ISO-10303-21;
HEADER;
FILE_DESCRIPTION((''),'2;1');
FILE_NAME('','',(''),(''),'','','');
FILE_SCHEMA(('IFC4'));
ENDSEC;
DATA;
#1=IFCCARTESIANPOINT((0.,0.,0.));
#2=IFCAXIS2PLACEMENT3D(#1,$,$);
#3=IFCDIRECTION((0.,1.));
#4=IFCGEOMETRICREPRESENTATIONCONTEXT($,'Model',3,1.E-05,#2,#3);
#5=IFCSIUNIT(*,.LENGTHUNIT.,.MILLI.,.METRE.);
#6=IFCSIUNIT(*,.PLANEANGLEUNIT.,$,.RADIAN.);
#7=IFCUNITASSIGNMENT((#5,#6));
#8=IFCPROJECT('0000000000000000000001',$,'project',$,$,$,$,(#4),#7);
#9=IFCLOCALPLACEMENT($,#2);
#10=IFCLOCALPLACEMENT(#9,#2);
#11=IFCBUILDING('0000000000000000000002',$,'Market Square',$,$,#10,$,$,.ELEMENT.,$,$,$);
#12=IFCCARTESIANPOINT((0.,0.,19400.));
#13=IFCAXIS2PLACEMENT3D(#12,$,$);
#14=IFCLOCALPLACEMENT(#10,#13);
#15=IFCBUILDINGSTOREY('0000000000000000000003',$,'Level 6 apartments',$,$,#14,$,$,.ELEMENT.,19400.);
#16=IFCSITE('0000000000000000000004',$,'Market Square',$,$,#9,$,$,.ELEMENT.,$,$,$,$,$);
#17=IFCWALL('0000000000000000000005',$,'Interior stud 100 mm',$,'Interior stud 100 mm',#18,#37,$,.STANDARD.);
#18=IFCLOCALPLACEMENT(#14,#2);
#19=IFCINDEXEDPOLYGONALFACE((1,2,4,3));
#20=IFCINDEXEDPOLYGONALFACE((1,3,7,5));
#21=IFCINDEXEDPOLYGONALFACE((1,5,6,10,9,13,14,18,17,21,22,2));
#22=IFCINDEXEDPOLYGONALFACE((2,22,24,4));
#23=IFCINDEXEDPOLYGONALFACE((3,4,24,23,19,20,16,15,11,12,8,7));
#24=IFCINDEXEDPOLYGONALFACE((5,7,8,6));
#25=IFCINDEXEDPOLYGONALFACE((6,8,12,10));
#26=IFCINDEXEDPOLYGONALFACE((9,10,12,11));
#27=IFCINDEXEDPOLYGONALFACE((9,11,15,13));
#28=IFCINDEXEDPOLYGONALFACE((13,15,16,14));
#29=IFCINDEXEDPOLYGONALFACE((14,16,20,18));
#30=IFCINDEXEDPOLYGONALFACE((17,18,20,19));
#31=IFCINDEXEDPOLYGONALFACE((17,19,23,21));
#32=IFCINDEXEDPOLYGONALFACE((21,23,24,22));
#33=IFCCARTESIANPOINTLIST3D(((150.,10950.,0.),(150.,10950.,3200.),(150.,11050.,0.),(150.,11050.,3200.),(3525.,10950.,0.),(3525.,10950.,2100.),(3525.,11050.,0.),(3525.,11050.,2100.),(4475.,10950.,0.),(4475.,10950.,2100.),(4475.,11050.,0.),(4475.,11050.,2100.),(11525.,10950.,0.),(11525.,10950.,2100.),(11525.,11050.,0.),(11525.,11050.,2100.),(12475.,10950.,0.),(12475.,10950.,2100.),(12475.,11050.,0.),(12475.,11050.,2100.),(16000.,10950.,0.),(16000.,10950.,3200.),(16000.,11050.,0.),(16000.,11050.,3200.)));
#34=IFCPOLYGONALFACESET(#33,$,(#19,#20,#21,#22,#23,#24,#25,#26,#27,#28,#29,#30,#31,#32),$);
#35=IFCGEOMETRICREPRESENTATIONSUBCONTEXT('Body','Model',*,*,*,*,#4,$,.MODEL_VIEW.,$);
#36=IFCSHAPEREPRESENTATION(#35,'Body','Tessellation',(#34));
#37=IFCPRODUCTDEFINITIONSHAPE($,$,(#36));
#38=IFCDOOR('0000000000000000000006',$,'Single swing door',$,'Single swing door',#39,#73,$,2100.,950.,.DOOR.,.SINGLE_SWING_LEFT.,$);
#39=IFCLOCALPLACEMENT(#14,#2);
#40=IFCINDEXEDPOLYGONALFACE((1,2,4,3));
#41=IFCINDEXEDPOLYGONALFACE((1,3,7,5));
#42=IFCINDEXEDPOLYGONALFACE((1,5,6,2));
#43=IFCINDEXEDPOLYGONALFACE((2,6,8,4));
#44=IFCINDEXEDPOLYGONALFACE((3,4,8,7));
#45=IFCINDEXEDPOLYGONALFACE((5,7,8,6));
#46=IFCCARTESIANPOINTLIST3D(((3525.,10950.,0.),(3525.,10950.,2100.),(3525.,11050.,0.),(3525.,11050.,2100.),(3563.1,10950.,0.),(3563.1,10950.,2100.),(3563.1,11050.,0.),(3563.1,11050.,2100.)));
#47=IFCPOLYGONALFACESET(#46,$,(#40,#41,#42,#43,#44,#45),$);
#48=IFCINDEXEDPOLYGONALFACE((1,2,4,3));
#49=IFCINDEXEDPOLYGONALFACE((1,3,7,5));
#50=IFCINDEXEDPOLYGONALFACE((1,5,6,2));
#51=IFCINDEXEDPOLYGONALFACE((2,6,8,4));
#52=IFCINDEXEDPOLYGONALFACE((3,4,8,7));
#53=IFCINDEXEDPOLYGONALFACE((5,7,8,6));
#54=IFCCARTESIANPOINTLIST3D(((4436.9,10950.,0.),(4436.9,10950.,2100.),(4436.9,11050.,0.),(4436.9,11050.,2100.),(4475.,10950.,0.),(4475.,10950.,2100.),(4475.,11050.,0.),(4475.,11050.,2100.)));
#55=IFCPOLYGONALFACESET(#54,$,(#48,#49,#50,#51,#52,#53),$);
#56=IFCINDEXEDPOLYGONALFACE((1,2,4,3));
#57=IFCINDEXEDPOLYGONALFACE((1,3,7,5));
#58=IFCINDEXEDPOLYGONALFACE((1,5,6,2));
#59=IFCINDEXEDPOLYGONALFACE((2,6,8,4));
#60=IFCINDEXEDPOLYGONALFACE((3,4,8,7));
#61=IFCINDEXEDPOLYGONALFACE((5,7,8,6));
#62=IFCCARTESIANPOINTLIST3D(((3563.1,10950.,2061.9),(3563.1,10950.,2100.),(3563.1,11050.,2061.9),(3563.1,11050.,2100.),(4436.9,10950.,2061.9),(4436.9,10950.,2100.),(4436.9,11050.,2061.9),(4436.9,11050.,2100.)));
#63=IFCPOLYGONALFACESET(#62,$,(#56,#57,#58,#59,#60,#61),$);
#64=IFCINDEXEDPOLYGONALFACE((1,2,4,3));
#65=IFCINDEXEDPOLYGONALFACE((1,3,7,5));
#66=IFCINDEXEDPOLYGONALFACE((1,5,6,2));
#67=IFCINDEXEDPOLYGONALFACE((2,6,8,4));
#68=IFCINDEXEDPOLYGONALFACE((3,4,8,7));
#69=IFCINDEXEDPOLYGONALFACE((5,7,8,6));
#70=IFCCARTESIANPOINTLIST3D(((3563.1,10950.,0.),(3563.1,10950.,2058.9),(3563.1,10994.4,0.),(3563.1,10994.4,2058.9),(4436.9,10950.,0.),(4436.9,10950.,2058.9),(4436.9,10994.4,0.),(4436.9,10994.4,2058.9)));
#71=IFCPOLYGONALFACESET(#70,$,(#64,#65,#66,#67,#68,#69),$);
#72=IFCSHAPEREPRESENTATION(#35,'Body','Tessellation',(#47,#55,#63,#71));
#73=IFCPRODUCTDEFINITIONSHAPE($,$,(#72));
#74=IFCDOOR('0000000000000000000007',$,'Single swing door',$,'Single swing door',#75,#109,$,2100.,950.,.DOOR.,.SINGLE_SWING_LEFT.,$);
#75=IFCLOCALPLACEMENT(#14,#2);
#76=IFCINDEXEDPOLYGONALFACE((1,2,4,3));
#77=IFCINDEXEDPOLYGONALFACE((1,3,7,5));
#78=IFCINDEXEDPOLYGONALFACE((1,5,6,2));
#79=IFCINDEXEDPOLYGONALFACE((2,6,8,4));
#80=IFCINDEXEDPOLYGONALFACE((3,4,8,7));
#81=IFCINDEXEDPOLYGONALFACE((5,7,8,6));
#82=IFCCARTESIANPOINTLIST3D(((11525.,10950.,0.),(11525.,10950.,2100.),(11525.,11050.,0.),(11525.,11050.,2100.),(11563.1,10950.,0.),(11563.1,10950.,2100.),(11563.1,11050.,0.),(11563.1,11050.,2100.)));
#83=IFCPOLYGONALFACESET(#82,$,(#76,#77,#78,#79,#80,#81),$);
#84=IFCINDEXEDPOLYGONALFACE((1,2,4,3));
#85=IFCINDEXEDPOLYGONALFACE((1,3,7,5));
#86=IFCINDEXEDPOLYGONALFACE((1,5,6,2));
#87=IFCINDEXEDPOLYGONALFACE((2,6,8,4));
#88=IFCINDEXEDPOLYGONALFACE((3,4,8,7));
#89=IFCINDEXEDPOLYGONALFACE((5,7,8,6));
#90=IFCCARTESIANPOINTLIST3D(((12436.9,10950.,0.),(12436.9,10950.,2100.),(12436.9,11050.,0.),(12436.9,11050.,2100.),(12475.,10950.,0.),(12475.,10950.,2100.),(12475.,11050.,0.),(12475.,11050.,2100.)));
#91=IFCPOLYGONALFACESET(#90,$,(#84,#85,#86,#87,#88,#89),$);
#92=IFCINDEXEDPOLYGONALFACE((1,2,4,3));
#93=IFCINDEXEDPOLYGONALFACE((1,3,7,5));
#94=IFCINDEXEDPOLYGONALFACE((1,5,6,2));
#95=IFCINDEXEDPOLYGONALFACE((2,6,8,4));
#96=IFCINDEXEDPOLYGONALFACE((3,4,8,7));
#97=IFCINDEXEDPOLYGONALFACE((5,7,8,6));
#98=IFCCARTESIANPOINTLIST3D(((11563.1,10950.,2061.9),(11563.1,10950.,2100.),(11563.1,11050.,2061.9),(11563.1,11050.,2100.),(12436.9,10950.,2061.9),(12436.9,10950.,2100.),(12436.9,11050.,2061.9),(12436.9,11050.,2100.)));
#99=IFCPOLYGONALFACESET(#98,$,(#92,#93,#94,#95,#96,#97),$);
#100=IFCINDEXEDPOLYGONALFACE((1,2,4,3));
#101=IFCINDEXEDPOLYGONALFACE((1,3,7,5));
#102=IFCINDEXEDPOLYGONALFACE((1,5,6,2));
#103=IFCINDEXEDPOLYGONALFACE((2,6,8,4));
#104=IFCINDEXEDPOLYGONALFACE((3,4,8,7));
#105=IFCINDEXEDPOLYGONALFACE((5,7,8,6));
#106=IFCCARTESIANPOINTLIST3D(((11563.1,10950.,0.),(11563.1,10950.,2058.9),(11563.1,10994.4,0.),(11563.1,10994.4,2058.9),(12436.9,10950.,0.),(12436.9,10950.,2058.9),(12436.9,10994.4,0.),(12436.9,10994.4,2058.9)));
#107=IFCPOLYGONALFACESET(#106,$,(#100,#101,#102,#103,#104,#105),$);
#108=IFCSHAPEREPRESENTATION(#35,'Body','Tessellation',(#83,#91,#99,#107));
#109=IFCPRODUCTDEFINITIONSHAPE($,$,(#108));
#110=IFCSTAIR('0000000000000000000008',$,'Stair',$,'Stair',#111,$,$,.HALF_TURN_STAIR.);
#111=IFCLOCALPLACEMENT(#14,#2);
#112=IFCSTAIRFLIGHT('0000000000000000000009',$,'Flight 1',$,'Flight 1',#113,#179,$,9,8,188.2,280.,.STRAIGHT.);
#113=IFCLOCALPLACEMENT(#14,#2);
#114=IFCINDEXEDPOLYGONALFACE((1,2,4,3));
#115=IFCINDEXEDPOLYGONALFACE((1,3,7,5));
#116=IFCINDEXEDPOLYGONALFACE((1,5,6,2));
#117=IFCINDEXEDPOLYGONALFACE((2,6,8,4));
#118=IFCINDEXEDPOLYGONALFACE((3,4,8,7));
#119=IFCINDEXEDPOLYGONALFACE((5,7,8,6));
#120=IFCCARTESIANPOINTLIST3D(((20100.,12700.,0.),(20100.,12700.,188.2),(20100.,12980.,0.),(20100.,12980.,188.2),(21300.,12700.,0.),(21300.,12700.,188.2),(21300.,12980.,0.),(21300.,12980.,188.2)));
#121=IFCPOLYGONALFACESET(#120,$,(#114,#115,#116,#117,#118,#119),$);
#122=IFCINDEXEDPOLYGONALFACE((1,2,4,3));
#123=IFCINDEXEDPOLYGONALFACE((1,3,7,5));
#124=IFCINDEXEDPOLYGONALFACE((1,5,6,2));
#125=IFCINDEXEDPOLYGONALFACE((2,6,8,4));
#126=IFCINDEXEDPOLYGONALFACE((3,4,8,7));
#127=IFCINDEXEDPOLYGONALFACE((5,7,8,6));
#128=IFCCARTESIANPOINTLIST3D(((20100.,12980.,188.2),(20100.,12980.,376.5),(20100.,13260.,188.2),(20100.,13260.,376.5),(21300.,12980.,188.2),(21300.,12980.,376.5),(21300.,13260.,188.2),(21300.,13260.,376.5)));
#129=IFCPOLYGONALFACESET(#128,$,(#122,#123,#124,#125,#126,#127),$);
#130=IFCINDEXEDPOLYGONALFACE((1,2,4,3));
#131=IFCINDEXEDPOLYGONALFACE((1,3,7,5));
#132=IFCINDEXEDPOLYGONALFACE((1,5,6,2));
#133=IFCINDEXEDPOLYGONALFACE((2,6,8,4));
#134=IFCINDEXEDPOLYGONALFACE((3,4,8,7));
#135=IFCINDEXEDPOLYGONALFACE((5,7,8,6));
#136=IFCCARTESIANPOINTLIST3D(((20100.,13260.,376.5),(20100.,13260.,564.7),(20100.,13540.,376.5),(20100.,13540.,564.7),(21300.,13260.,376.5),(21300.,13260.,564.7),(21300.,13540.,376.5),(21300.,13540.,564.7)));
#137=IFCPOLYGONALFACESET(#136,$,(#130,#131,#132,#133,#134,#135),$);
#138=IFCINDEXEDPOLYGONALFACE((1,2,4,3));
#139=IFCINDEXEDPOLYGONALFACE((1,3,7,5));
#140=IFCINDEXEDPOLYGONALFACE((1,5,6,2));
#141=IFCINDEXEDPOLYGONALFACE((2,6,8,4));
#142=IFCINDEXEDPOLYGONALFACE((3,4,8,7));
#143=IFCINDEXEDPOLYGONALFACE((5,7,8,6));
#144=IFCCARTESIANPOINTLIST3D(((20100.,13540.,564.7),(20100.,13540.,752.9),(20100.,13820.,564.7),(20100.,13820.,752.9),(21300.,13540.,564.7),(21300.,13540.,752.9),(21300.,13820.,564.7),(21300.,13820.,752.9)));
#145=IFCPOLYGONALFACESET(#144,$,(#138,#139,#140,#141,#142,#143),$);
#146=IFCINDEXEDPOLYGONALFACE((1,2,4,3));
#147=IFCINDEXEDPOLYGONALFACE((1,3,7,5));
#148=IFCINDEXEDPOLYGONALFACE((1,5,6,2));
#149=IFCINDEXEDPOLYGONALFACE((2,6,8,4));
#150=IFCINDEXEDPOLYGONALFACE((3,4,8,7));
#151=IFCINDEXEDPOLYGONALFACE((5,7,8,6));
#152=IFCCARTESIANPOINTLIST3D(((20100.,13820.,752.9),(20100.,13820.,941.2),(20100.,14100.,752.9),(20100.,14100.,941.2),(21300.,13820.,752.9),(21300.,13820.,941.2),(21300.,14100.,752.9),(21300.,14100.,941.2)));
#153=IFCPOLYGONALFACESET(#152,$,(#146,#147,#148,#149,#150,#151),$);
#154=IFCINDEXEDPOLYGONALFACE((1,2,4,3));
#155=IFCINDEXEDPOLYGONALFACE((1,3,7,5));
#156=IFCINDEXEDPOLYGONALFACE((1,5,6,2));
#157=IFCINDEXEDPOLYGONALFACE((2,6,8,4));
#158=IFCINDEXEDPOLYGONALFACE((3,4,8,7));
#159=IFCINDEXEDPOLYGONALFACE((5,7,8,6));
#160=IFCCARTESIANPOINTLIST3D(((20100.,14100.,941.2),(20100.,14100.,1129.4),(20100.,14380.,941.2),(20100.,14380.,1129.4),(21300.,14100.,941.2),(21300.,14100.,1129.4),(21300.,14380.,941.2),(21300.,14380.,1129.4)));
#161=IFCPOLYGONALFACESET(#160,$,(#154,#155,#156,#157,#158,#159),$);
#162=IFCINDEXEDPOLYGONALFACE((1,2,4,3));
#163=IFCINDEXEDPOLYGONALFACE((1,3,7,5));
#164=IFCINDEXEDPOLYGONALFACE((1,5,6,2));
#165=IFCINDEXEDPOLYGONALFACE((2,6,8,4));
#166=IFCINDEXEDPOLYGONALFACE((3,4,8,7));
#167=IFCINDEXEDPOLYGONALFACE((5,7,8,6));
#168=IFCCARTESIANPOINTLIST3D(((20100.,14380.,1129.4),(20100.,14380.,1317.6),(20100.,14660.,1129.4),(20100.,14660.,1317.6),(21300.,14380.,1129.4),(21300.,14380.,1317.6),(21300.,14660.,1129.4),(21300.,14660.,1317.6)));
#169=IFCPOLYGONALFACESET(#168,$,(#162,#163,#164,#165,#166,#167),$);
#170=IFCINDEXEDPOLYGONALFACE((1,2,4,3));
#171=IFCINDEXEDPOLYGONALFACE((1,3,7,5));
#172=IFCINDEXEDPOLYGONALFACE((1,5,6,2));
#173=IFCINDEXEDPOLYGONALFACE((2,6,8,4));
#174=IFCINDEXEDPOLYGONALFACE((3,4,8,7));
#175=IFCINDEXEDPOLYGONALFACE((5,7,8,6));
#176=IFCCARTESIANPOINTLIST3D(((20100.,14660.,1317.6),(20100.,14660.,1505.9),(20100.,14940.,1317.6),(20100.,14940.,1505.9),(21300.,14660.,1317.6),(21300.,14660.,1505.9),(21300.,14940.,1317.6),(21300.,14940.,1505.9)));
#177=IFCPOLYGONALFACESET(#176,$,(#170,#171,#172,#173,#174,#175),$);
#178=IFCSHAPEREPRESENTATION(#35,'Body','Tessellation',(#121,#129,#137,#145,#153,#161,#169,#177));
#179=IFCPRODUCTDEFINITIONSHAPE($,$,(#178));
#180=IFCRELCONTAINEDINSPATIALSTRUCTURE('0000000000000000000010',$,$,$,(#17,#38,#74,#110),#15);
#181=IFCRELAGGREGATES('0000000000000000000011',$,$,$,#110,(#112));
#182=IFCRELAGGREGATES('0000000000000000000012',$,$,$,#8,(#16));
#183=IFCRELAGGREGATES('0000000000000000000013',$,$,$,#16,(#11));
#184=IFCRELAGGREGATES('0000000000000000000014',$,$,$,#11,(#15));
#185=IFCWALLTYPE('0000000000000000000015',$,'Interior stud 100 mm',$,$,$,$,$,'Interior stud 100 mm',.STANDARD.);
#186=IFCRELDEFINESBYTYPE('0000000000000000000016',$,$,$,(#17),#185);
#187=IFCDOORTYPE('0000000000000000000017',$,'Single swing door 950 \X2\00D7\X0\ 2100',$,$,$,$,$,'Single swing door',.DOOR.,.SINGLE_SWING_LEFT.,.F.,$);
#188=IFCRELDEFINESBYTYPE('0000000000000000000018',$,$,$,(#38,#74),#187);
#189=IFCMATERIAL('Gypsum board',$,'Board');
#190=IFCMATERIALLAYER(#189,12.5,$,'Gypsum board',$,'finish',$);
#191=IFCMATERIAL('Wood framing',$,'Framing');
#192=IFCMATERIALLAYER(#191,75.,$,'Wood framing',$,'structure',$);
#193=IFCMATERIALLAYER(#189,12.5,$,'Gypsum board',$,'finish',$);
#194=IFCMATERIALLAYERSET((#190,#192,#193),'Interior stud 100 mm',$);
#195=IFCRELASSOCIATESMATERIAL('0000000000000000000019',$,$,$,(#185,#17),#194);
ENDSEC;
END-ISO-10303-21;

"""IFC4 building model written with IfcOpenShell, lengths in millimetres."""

from ifc_helpers import new_model, si_unit, direction, frame, origin, origin_with_axes, place, context, subcontext, project, spatial, polyline, outline, extrude, material, layer, layer_set, layer_usage, type_object, element, fill, aggregate, save


model = new_model("IFC4")

# Units and contexts
model_context = context("Model", 3, precision=1e-05, world=origin(), true_north=direction((0.0, 1.0)))
body_context = subcontext(model_context, "Body", "Model", "MODEL_VIEW")
ifc_project = project(units=[si_unit("LENGTHUNIT", "METRE", prefix="MILLI"), si_unit("PLANEANGLEUNIT", "RADIAN")], contexts=[model_context])

# Site, building, storey
site_placement = place(None, origin())
site = spatial("IfcSite", under=ifc_project, at=site_placement, Name="Market Square", CompositionType="ELEMENT")
building_placement = place(site_placement, origin())
building = spatial("IfcBuilding", under=site, at=building_placement, Name="Market Square", CompositionType="ELEMENT")
storey_placement = place(building_placement, frame((0.0, 0.0, 19400.0)))
storey = spatial("IfcBuildingStorey", under=building, at=storey_placement, Name="Level 6 apartments", CompositionType="ELEMENT", Elevation=19400.0)

# Wall, openings, doors
ifc_material_1 = material(Name="Gypsum board", Category="Board")
ifc_layer_1 = layer(ifc_material_1, 12.5, Name="Gypsum board", Category="finish")
ifc_material_2 = material(Name="Wood framing", Category="Framing")
ifc_layer_2 = layer(ifc_material_2, 75.0, Name="Wood framing", Category="structure")
ifc_layer_3 = layer(ifc_material_1, 12.5, Name="Gypsum board", Category="finish")
ifc_layer_set_1 = layer_set([ifc_layer_1, ifc_layer_2, ifc_layer_3], Name="Interior stud 100 mm")
wall_type_1 = type_object("IfcWallType", Name="Interior stud 100 mm", ElementType="Interior stud 100 mm", PredefinedType="STANDARD", material=ifc_layer_set_1)
door_type = type_object("IfcDoorType", Name="Single swing door 950 × 2100", ElementType="Single swing door", OperationType="SINGLE_SWING_LEFT", ParameterTakesPrecedence=False, PredefinedType="DOOR")
ifc_layer_usage_1 = layer_usage(ifc_layer_set_1, "AXIS2", "NEGATIVE", 50.0)
wall_1_placement = place(storey_placement, frame((0.0, 11000.0, 0.0), z_axis=(0.0, 0.0, 1.0), x_axis=(1.0, 0.0, 0.0)))
wall_1 = element("IfcWall", 1, at=wall_1_placement, inside=storey, type_object=wall_type_1, material=ifc_layer_usage_1, Name="Interior stud 100 mm", ObjectType="Interior stud 100 mm", PredefinedType="STANDARD", context=body_context, shape_type="SweptSolid", body=[
    extrude(outline(polyline([(150.0, -50.0), (16000.0, -50.0), (16000.0, 50.0), (150.0, 50.0), (150.0, -50.0)])), origin(), (0.0, 0.0, 1.0), 3200.0),
])
opening_1_placement = place(wall_1_placement, frame((3525.0, 0.0, 0.0), z_axis=(0.0, 0.0, 1.0), x_axis=(1.0, 0.0, 0.0)))
opening_1 = element("IfcOpeningElement", 2, at=opening_1_placement, cuts=wall_1, PredefinedType="OPENING", context=body_context, shape_type="SweptSolid", body=[
    extrude(outline(polyline([(0.0, -60.0), (950.0, -60.0), (950.0, 60.0), (0.0, 60.0), (0.0, -60.0)])), origin(), (0.0, 0.0, 1.0), 2100.0),
])
opening_2_placement = place(wall_1_placement, frame((11525.0, 0.0, 0.0), z_axis=(0.0, 0.0, 1.0), x_axis=(1.0, 0.0, 0.0)))
opening_2 = element("IfcOpeningElement", 3, at=opening_2_placement, cuts=wall_1, PredefinedType="OPENING", context=body_context, shape_type="SweptSolid", body=[
    extrude(outline(polyline([(0.0, -60.0), (950.0, -60.0), (950.0, 60.0), (0.0, 60.0), (0.0, -60.0)])), origin(), (0.0, 0.0, 1.0), 2100.0),
])
door_1_placement = place(opening_1_placement, origin_with_axes())
door_1 = element("IfcDoor", 4, at=door_1_placement, inside=storey, type_object=door_type, Name="Single swing door", ObjectType="Single swing door", OperationType="SINGLE_SWING_LEFT", OverallHeight=2100.0, OverallWidth=950.0, PredefinedType="DOOR", context=body_context, shape_type="SweptSolid", body=[
    extrude(outline(polyline([(0.0, -50.0), (38.1, -50.0), (38.1, 50.0), (0.0, 50.0), (0.0, -50.0)])), origin(), (0.0, 0.0, 1.0), 2100.0),
    extrude(outline(polyline([(911.9, -50.0), (950.0, -50.0), (950.0, 50.0), (911.9, 50.0), (911.9, -50.0)])), origin(), (0.0, 0.0, 1.0), 2100.0),
    extrude(outline(polyline([(38.1, -50.0), (911.9, -50.0), (911.9, 50.0), (38.1, 50.0), (38.1, -50.0)])), frame((0.0, 0.0, 2061.9)), (0.0, 0.0, 1.0), 38.1),
    extrude(outline(polyline([(38.1, -50.0), (911.9, -50.0), (911.9, -5.5), (38.1, -5.5), (38.1, -50.0)])), origin(), (0.0, 0.0, 1.0), 2058.9),
])
fill(opening_1, door_1)
door_2_placement = place(opening_2_placement, origin_with_axes())
door_2 = element("IfcDoor", 5, at=door_2_placement, inside=storey, type_object=door_type, Name="Single swing door", ObjectType="Single swing door", OperationType="SINGLE_SWING_LEFT", OverallHeight=2100.0, OverallWidth=950.0, PredefinedType="DOOR", context=body_context, shape_type="SweptSolid", body=[
    extrude(outline(polyline([(0.0, -50.0), (38.1, -50.0), (38.1, 50.0), (0.0, 50.0), (0.0, -50.0)])), origin(), (0.0, 0.0, 1.0), 2100.0),
    extrude(outline(polyline([(911.9, -50.0), (950.0, -50.0), (950.0, 50.0), (911.9, 50.0), (911.9, -50.0)])), origin(), (0.0, 0.0, 1.0), 2100.0),
    extrude(outline(polyline([(38.1, -50.0), (911.9, -50.0), (911.9, 50.0), (38.1, 50.0), (38.1, -50.0)])), frame((0.0, 0.0, 2061.9)), (0.0, 0.0, 1.0), 38.1),
    extrude(outline(polyline([(38.1, -50.0), (911.9, -50.0), (911.9, -5.5), (38.1, -5.5), (38.1, -50.0)])), origin(), (0.0, 0.0, 1.0), 2058.9),
])
fill(opening_2, door_2)

# Stair, stair flight
stair_placement = place(storey_placement, origin_with_axes())
stair = element("IfcStair", 6, at=stair_placement, inside=storey, Name="Stair", ObjectType="Stair", PredefinedType="HALF_TURN_STAIR")
stair_flight_placement = place(storey_placement, origin_with_axes())
stair_flight = element("IfcStairFlight", 7, at=stair_flight_placement, Name="Flight 1", ObjectType="Flight 1", NumberOfRisers=9, NumberOfTreads=8, PredefinedType="STRAIGHT", RiserHeight=188.2, TreadLength=280.0, context=body_context, shape_type="SweptSolid", body=[
    extrude(outline(polyline([(21300.0, 12700.0), (21300.0, 12980.0), (20100.0, 12980.0), (20100.0, 12700.0), (21300.0, 12700.0)])), origin(), (0.0, 0.0, 1.0), 188.2),
    extrude(outline(polyline([(21300.0, 12980.0), (21300.0, 13260.0), (20100.0, 13260.0), (20100.0, 12980.0), (21300.0, 12980.0)])), frame((0.0, 0.0, 188.2)), (0.0, 0.0, 1.0), 188.2),
    extrude(outline(polyline([(21300.0, 13260.0), (21300.0, 13540.0), (20100.0, 13540.0), (20100.0, 13260.0), (21300.0, 13260.0)])), frame((0.0, 0.0, 376.5)), (0.0, 0.0, 1.0), 188.2),
    extrude(outline(polyline([(21300.0, 13540.0), (21300.0, 13820.0), (20100.0, 13820.0), (20100.0, 13540.0), (21300.0, 13540.0)])), frame((0.0, 0.0, 564.7)), (0.0, 0.0, 1.0), 188.2),
    extrude(outline(polyline([(21300.0, 13820.0), (21300.0, 14100.0), (20100.0, 14100.0), (20100.0, 13820.0), (21300.0, 13820.0)])), frame((0.0, 0.0, 752.9)), (0.0, 0.0, 1.0), 188.2),
    extrude(outline(polyline([(21300.0, 14100.0), (21300.0, 14380.0), (20100.0, 14380.0), (20100.0, 14100.0), (21300.0, 14100.0)])), frame((0.0, 0.0, 941.2)), (0.0, 0.0, 1.0), 188.2),
    extrude(outline(polyline([(21300.0, 14380.0), (21300.0, 14660.0), (20100.0, 14660.0), (20100.0, 14380.0), (21300.0, 14380.0)])), frame((0.0, 0.0, 1129.4)), (0.0, 0.0, 1.0), 188.2),
    extrude(outline(polyline([(21300.0, 14660.0), (21300.0, 14940.0), (20100.0, 14940.0), (20100.0, 14660.0), (21300.0, 14660.0)])), frame((0.0, 0.0, 1317.6)), (0.0, 0.0, 1.0), 188.2),
])
aggregate(stair, [stair_flight])

save(model, "model.ifc")
